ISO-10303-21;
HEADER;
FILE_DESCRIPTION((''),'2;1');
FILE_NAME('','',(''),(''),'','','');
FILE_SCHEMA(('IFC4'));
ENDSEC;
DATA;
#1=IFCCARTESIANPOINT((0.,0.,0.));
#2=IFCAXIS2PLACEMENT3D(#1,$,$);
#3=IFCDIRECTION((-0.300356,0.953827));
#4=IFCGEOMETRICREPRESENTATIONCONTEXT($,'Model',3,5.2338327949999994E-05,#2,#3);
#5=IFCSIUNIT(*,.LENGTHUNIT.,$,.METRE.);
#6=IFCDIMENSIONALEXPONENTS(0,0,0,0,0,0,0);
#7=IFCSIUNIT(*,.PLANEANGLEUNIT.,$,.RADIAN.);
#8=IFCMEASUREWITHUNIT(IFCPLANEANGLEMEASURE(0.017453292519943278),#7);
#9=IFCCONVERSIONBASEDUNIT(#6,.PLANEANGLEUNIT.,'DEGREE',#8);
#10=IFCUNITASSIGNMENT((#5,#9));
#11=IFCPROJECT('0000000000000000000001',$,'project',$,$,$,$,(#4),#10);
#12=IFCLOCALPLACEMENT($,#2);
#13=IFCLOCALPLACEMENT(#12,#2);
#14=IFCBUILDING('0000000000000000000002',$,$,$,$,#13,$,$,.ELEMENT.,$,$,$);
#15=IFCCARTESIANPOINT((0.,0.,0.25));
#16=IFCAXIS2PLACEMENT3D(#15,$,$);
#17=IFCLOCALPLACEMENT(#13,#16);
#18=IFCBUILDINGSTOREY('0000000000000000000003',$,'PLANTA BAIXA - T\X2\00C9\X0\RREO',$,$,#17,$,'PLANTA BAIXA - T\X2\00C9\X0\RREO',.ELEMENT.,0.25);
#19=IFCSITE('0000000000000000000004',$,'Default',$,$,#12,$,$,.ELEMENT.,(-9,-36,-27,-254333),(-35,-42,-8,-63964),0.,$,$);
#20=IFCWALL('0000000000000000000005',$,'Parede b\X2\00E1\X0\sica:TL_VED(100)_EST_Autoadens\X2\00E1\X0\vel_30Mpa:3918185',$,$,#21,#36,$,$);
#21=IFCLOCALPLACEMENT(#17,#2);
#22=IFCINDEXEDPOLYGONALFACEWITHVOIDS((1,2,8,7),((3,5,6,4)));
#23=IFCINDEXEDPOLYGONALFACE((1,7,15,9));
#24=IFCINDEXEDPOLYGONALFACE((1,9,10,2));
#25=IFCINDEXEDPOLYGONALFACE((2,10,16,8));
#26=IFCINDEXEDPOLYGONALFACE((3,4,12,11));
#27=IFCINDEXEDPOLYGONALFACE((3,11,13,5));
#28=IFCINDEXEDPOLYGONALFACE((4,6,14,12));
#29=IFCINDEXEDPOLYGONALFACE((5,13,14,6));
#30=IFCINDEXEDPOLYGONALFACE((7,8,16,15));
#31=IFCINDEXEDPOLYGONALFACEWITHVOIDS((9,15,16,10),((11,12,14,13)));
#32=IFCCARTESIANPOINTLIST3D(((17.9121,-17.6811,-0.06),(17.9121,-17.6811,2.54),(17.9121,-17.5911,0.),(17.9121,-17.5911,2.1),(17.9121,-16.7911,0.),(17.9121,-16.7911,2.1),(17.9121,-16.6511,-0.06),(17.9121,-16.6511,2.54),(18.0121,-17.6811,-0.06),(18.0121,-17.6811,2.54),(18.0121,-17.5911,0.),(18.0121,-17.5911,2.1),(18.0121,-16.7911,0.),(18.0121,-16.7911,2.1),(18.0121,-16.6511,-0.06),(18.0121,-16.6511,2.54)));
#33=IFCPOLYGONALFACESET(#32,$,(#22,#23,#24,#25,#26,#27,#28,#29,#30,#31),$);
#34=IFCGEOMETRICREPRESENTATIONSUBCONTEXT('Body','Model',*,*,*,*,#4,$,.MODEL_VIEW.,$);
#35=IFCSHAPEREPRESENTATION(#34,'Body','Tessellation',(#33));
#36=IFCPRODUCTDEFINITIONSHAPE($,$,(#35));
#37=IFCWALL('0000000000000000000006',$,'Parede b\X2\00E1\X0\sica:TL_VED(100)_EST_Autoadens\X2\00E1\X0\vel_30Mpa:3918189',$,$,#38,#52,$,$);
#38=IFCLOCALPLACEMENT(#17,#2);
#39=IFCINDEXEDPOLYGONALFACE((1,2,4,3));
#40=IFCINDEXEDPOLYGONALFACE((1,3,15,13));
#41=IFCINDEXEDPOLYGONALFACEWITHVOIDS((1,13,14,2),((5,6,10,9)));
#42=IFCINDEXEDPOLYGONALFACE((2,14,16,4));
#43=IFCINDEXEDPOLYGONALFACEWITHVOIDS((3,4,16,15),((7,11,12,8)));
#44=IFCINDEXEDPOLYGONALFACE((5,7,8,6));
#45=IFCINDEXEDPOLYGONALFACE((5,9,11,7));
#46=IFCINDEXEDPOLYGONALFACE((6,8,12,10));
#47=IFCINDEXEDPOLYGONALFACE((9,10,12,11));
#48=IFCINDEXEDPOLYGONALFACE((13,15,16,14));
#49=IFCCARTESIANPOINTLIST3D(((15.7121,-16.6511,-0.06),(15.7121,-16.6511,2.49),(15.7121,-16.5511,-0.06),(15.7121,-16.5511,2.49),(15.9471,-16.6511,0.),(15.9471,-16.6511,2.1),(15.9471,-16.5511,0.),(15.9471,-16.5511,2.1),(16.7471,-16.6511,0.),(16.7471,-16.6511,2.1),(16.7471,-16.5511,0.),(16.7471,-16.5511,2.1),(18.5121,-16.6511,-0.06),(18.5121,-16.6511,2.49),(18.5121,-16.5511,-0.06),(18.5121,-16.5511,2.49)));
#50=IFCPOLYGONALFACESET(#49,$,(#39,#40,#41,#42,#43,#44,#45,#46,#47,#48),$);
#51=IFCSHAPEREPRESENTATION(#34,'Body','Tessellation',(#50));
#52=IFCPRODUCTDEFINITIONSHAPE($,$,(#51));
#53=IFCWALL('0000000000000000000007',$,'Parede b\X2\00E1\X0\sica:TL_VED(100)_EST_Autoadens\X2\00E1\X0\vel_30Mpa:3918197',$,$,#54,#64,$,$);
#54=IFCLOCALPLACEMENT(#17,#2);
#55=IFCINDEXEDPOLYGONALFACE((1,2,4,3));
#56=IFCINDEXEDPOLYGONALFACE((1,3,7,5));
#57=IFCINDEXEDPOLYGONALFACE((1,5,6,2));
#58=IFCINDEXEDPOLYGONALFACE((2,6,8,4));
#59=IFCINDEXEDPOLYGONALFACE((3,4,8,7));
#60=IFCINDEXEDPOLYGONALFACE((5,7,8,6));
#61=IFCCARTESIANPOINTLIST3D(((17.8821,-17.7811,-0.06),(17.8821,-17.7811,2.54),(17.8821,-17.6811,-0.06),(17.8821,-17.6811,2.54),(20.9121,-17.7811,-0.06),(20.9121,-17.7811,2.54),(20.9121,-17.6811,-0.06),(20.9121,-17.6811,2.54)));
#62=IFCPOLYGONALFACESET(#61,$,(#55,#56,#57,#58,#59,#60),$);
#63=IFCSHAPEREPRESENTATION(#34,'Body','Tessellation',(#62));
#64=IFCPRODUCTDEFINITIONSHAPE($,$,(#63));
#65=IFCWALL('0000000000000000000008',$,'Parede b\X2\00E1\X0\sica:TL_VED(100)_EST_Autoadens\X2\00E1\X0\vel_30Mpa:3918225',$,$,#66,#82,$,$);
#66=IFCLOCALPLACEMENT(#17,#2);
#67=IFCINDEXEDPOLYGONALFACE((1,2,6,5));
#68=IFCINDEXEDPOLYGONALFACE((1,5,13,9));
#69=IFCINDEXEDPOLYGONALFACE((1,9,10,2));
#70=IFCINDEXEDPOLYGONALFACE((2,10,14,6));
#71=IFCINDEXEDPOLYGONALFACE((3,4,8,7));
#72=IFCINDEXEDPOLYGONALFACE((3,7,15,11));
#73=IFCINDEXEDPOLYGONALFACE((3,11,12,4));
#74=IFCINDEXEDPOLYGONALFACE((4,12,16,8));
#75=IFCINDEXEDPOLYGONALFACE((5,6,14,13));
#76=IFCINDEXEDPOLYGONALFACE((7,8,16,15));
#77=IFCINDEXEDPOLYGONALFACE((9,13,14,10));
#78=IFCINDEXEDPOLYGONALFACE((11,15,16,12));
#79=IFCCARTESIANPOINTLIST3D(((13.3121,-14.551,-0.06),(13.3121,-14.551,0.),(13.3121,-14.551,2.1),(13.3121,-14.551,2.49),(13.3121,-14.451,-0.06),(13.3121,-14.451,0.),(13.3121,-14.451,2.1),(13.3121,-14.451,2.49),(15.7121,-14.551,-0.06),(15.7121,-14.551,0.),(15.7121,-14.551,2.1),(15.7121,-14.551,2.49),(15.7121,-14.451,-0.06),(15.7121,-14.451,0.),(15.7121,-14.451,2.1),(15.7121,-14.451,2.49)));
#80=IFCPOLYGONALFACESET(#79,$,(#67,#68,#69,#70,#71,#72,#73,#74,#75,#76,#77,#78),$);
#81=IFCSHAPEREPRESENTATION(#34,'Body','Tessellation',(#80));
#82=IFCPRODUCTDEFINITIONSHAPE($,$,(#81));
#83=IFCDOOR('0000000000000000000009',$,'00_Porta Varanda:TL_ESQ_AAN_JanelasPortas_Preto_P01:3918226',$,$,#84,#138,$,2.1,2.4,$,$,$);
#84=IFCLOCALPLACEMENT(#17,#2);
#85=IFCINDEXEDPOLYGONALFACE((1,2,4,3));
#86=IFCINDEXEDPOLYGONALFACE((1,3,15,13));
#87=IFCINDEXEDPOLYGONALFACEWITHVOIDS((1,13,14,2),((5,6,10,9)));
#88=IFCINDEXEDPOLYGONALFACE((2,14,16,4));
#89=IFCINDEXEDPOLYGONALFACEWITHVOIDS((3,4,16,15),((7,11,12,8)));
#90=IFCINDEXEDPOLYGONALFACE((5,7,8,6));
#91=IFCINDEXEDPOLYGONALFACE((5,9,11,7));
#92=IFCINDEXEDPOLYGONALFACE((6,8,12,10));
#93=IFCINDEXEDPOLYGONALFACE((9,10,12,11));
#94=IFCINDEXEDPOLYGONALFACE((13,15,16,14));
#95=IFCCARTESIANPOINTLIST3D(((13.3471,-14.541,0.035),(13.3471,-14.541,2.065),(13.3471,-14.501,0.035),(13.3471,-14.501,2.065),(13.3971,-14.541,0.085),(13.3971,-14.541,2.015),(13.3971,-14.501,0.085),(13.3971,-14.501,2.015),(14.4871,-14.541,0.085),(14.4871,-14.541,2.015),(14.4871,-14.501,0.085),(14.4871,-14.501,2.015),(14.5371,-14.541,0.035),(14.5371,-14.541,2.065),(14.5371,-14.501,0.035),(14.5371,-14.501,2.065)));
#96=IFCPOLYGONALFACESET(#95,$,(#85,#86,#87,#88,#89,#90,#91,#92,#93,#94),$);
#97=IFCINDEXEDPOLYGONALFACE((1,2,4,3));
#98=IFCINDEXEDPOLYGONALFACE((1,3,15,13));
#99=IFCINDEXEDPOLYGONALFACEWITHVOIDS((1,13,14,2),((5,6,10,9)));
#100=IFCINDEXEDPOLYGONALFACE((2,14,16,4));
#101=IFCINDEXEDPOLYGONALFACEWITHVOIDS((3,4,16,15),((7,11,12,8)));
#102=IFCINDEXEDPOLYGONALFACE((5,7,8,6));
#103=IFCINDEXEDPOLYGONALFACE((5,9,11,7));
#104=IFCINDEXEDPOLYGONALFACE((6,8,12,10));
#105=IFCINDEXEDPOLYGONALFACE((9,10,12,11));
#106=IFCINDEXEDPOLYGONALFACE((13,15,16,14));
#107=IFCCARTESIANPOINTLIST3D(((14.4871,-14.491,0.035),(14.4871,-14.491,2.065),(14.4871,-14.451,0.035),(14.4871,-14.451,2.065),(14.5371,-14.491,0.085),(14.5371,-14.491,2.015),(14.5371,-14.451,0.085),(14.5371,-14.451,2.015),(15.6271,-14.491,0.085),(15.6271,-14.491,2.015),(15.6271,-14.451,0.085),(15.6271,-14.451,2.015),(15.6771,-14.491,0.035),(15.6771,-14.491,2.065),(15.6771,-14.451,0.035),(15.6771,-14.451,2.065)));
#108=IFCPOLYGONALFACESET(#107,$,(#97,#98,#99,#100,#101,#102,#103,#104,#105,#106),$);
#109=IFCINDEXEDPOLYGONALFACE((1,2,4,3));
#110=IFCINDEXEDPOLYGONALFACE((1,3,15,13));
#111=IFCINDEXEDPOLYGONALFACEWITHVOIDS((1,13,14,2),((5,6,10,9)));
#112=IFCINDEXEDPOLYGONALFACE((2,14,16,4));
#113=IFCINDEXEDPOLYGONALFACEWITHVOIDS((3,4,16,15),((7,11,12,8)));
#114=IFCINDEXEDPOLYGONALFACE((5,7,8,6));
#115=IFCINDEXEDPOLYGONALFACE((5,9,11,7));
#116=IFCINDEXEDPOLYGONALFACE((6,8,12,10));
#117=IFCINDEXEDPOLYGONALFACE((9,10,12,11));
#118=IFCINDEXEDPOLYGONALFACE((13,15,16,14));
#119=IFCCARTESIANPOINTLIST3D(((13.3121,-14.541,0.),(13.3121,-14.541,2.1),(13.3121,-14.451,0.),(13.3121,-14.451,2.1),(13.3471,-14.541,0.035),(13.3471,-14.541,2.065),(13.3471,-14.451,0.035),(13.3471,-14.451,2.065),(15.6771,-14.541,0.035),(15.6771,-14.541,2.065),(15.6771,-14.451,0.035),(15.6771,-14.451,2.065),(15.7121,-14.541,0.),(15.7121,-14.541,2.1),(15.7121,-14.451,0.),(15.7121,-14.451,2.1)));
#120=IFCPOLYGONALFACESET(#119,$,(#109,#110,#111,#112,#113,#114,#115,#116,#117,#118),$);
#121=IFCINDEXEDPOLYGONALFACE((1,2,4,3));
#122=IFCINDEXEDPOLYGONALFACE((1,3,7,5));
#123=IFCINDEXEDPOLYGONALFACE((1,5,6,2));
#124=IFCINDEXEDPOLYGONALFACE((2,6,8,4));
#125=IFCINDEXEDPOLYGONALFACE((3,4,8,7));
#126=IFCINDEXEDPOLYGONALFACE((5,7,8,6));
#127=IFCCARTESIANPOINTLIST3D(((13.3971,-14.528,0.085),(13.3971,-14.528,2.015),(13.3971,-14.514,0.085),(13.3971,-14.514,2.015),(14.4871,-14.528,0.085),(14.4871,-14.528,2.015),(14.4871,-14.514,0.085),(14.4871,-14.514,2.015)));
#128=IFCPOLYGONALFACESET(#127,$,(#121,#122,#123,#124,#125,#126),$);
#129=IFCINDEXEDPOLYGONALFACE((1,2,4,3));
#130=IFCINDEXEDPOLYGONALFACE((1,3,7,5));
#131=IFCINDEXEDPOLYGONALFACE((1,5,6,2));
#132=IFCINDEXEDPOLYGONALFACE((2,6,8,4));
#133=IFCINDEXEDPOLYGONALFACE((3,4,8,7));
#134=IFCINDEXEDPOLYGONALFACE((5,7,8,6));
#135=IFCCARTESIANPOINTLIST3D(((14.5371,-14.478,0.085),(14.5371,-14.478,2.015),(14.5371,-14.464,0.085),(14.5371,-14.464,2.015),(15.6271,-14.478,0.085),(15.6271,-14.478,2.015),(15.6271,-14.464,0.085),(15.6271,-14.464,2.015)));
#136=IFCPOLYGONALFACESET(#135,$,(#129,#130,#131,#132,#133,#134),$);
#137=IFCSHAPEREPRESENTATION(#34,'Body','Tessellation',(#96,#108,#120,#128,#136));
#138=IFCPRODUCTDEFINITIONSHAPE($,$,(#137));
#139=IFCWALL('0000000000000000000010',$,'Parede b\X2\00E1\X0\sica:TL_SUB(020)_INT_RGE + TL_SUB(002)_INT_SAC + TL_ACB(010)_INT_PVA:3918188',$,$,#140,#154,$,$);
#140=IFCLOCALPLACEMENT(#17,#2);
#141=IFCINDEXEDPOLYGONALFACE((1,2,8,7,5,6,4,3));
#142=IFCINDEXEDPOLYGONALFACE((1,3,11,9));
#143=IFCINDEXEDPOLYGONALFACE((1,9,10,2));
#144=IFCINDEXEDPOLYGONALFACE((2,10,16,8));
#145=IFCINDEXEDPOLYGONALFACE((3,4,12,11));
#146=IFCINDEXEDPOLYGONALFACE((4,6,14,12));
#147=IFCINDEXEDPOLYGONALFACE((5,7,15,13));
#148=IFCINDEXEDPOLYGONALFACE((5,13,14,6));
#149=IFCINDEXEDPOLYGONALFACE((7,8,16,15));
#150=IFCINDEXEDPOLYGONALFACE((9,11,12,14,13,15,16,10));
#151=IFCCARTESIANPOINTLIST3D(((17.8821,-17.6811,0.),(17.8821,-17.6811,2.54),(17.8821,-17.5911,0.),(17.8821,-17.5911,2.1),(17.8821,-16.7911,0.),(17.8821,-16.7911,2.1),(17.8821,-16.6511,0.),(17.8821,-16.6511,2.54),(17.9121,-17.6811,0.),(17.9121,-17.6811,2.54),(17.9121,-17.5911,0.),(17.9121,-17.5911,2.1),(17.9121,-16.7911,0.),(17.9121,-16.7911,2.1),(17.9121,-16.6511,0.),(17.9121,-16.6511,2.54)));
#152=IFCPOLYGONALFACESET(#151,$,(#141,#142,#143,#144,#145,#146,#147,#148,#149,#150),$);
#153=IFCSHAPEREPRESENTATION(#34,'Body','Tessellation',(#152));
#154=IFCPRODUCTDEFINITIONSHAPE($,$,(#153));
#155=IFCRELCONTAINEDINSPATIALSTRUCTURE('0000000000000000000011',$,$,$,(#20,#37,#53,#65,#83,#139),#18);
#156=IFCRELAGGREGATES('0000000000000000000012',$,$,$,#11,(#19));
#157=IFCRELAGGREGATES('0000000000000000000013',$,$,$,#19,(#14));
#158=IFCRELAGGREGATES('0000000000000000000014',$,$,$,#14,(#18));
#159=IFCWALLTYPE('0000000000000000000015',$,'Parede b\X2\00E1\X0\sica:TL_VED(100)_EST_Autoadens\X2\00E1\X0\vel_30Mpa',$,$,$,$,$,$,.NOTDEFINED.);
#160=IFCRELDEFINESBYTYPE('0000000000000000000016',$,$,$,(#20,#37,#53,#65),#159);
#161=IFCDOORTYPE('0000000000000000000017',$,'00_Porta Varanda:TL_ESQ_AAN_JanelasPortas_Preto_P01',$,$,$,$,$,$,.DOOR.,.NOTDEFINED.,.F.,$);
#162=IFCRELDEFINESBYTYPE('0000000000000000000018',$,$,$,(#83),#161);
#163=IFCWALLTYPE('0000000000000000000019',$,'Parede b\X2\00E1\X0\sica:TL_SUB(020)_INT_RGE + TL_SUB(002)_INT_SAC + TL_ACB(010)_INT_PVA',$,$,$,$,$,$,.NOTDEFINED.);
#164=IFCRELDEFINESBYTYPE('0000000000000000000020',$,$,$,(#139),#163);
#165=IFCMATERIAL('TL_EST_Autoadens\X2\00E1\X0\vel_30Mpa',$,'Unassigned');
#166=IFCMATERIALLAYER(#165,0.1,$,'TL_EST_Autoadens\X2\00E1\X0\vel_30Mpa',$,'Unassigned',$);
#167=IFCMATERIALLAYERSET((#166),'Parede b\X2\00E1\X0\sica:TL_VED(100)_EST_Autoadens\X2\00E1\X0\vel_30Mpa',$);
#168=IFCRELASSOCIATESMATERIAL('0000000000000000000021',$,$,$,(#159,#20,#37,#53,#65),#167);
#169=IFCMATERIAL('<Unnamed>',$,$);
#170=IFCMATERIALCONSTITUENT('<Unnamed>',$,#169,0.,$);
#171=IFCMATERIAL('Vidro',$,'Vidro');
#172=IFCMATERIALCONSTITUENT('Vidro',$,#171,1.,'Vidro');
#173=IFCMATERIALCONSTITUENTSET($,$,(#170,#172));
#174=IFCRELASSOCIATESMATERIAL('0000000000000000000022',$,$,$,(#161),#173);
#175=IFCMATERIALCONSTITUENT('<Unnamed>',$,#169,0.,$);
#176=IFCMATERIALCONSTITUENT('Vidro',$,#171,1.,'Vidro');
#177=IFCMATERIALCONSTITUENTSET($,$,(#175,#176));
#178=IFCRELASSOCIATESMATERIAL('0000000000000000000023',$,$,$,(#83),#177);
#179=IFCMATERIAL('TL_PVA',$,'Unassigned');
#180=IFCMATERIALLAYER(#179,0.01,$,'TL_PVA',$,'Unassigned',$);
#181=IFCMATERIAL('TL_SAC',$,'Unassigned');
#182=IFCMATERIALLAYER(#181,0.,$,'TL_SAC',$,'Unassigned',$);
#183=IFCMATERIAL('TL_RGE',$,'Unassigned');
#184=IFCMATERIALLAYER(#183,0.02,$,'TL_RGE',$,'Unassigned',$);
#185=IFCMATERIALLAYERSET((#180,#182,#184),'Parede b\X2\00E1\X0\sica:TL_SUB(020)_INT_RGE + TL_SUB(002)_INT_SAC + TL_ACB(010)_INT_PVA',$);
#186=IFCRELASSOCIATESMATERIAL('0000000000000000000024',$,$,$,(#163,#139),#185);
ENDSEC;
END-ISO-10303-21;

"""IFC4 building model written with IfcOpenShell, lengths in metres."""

from ifc_helpers import new_model, entity, si_unit, converted_unit, direction, frame, frame_2d, origin, place, context, subcontext, project, spatial, polyline, rectangle, outline, extrude, source, transform, mapped, material, layer, layer_set, layer_usage, constituent, constituent_set, type_object, type_shapes, element, fill, save


model = new_model("IFC4")

# Units and contexts
model_context = context("Model", 3, precision=5.2338327949999994e-05, world=origin(), true_north=direction((-0.300356, 0.953827)))
body_context = subcontext(model_context, "Body", "Model", "MODEL_VIEW")
ifc_project = project(units=[si_unit("LENGTHUNIT", "METRE"), converted_unit("PLANEANGLEUNIT", "DEGREE", entity("IfcPlaneAngleMeasure", 0.017453292519943278), si_unit("PLANEANGLEUNIT", "RADIAN"), dimensions=[0, 0, 0, 0, 0, 0, 0])], contexts=[model_context])

# Site, building, storey
site_placement = place(None, origin())
site = spatial("IfcSite", under=ifc_project, at=site_placement, Name="Default", CompositionType="ELEMENT", RefLatitude=(-9, -36, -27, -254333), RefLongitude=(-35, -42, -8, -63964), RefElevation=0.0)
building_placement = place(site_placement, origin())
building = spatial("IfcBuilding", under=site, at=building_placement, CompositionType="ELEMENT")
storey_placement = place(building_placement, frame((0.0, 0.0, 0.25)))
storey = spatial("IfcBuildingStorey", under=building, at=storey_placement, Name="PLANTA BAIXA - TÉRREO", LongName="PLANTA BAIXA - TÉRREO", CompositionType="ELEMENT", Elevation=0.25)

# Walls, openings
ifc_material_1 = material(Name="TL_EST_Autoadensável_30Mpa", Category="Unassigned")
ifc_layer_1 = layer(ifc_material_1, 0.1, Name="TL_EST_Autoadensável_30Mpa", Category="Unassigned")
ifc_layer_set_1 = layer_set([ifc_layer_1], Name="Parede básica:TL_VED(100)_EST_Autoadensável_30Mpa")
ifc_layer_usage_1 = layer_usage(ifc_layer_set_1, "AXIS2", "NEGATIVE", 0.05)
wall_type_1 = type_object("IfcWallType", Name="Parede básica:TL_VED(100)_EST_Autoadensável_30Mpa", PredefinedType="NOTDEFINED", material=ifc_layer_set_1)
wall_1_placement = place(storey_placement, frame((17.9621, -16.6511, -0.06), z_axis=(0.0, 0.0, 1.0), x_axis=(0.0, -1.0, 0.0)))
wall_1 = element("IfcWall", 1, at=wall_1_placement, inside=storey, type_object=wall_type_1, material=ifc_layer_usage_1, Name="Parede básica:TL_VED(100)_EST_Autoadensável_30Mpa:3918185", context=body_context, shape_type="SweptSolid", body=[
    extrude(rectangle(XDim=1.03, YDim=0.1, at=frame_2d((0.515, 0.0), x_axis=(-1.0, 0.0))), origin(), (0.0, 0.0, 1.0), 2.6),
])
opening_1_placement = place(wall_1_placement, frame((0.14, -0.05, 0.06)))
element("IfcOpeningElement", 2, at=opening_1_placement, cuts=wall_1, PredefinedType="OPENING", context=body_context, shape_type="SweptSolid", body=[
    extrude(rectangle(XDim=2.1, YDim=0.8, at=frame_2d((1.05, 0.4), x_axis=(1.0, 0.0))), frame((0.0, 0.0, 0.0), z_axis=(0.0, 1.0, 0.0), x_axis=(0.0, 0.0, 1.0)), (0.0, 0.0, 1.0), 0.1),
])
ifc_layer_usage_2 = layer_usage(ifc_layer_set_1, "AXIS2", "NEGATIVE", 0.05)
wall_2_placement = place(storey_placement, frame((15.7121, -16.6011, -0.06)))
wall_2 = element("IfcWall", 3, at=wall_2_placement, inside=storey, type_object=wall_type_1, material=ifc_layer_usage_2, Name="Parede básica:TL_VED(100)_EST_Autoadensável_30Mpa:3918189", context=body_context, shape_type="SweptSolid", body=[
    extrude(rectangle(XDim=2.8, YDim=0.1, at=frame_2d((1.4, 0.0), x_axis=(-1.0, 0.0))), origin(), (0.0, 0.0, 1.0), 2.55),
])
opening_2_placement = place(wall_2_placement, frame((0.235, -0.05, 0.06)))
element("IfcOpeningElement", 4, at=opening_2_placement, cuts=wall_2, PredefinedType="OPENING", context=body_context, shape_type="SweptSolid", body=[
    extrude(rectangle(XDim=2.1, YDim=0.8, at=frame_2d((1.05, 0.4), x_axis=(1.0, 0.0))), frame((0.0, 0.0, 0.0), z_axis=(0.0, 1.0, 0.0), x_axis=(0.0, 0.0, 1.0)), (0.0, 0.0, 1.0), 0.1),
])

# Wall
ifc_layer_usage_3 = layer_usage(ifc_layer_set_1, "AXIS2", "POSITIVE", -0.05)
wall_3_placement = place(storey_placement, frame((17.8821, -17.7311, -0.06)))
element("IfcWall", 5, at=wall_3_placement, inside=storey, type_object=wall_type_1, material=ifc_layer_usage_3, Name="Parede básica:TL_VED(100)_EST_Autoadensável_30Mpa:3918197", context=body_context, shape_type="SweptSolid", body=[
    extrude(rectangle(XDim=3.03, YDim=0.1, at=frame_2d((1.515, 0.0), x_axis=(-1.0, 0.0))), origin(), (0.0, 0.0, 1.0), 2.6),
])

# Wall, opening, door
ifc_layer_usage_4 = layer_usage(ifc_layer_set_1, "AXIS2", "POSITIVE", -0.05)
wall_4_placement = place(storey_placement, frame((15.7121, -14.501, -0.06), z_axis=(0.0, 0.0, 1.0), x_axis=(-1.0, 0.0, 0.0)))
wall_4 = element("IfcWall", 6, at=wall_4_placement, inside=storey, type_object=wall_type_1, material=ifc_layer_usage_4, Name="Parede básica:TL_VED(100)_EST_Autoadensável_30Mpa:3918225", context=body_context, shape_type="SweptSolid", body=[
    extrude(rectangle(XDim=2.4, YDim=0.1, at=frame_2d((1.2, 0.0), x_axis=(-1.0, 0.0))), origin(), (0.0, 0.0, 1.0), 2.55),
])
opening_3_placement = place(wall_4_placement, frame((0.0, -0.05, 0.06)))
opening_3 = element("IfcOpeningElement", 7, at=opening_3_placement, cuts=wall_4, PredefinedType="OPENING", context=body_context, shape_type="SweptSolid", body=[
    extrude(rectangle(XDim=2.1, YDim=2.4, at=frame_2d((1.05, 1.2), x_axis=(1.0, 0.0))), frame((0.0, 0.0, 0.0), z_axis=(0.0, 1.0, 0.0), x_axis=(0.0, 0.0, 1.0)), (0.0, 0.0, 1.0), 0.1),
])
ifc_material_2 = material(Name="<Unnamed>")
ifc_constituent_1 = constituent(ifc_material_2, Name="<Unnamed>", fraction=0.0)
ifc_material_3 = material(Name="Vidro", Category="Vidro")
ifc_constituent_2 = constituent(ifc_material_3, Name="Vidro", Category="Vidro", fraction=1.0)
ifc_constituent_set_1 = constituent_set(constituents=[ifc_constituent_1, ifc_constituent_2])
ifc_constituent_3 = constituent(ifc_material_2, Name="<Unnamed>", fraction=0.0)
ifc_constituent_4 = constituent(ifc_material_3, Name="Vidro", Category="Vidro", fraction=1.0)
ifc_constituent_set_2 = constituent_set(constituents=[ifc_constituent_3, ifc_constituent_4])
door_type = type_object("IfcDoorType", Name="00_Porta Varanda:TL_ESQ_AAN_JanelasPortas_Preto_P01", OperationType="NOTDEFINED", ParameterTakesPrecedence=False, PredefinedType="DOOR", material=ifc_constituent_set_2)
shared_shape = source(origin(), body_context, "Body", "SweptSolid", [
    extrude(outline(polyline([(-1.015, -0.595), (1.015, -0.595), (1.015, 0.595), (-1.015, 0.595), (-1.015, -0.595)]), holes=[polyline([(0.965, -0.545), (-0.965, -0.545), (-0.965, 0.545), (0.965, 0.545), (0.965, -0.545)])]), frame((1.77, 0.05, 1.05), z_axis=(0.0, 1.0, 0.0), x_axis=(0.0, 0.0, 1.0)), (0.0, 0.0, 1.0), 0.04),
    extrude(outline(polyline([(-1.015, -0.595), (1.015, -0.595), (1.015, 0.595), (-1.015, 0.595), (-1.015, -0.595)]), holes=[polyline([(0.965, -0.545), (-0.965, -0.545), (-0.965, 0.545), (0.965, 0.545), (0.965, -0.545)])]), frame((0.63, 0.0, 1.05), z_axis=(0.0, 1.0, 0.0), x_axis=(0.0, 0.0, -1.0)), (0.0, 0.0, 1.0), 0.04),
    extrude(outline(polyline([(-1.05, -1.2), (1.05, -1.2), (1.05, 1.2), (-1.05, 1.2), (-1.05, -1.2)]), holes=[polyline([(1.015, -1.165), (-1.015, -1.165), (-1.015, 1.165), (1.015, 1.165), (1.015, -1.165)])]), frame((1.2, 0.0, 1.05), z_axis=(0.0, 1.0, 0.0), x_axis=(0.0, 0.0, -1.0)), (0.0, 0.0, 1.0), 0.09),
    extrude(rectangle(XDim=0.014, YDim=1.09, at=frame_2d((0.0, 0.0), x_axis=(1.0, 0.0))), frame((1.77, 0.07, 0.085), z_axis=(0.0, 0.0, 1.0), x_axis=(0.0, -1.0, 0.0)), (0.0, 0.0, 1.0), 1.93),
    extrude(rectangle(XDim=0.014, YDim=1.09, at=frame_2d((0.0, 0.0), x_axis=(1.0, 0.0))), frame((0.63, 0.02, 0.085), z_axis=(0.0, 0.0, 1.0), x_axis=(0.0, -1.0, 0.0)), (0.0, 0.0, 1.0), 1.93),
])
type_shapes(door_type, [shared_shape])
door_placement = place(opening_3_placement, origin())
door = element("IfcDoor", 8, at=door_placement, inside=storey, type_object=door_type, material=ifc_constituent_set_1, Name="00_Porta Varanda:TL_ESQ_AAN_JanelasPortas_Preto_P01:3918226", OverallHeight=2.1, OverallWidth=2.4, context=body_context, shape_type="MappedRepresentation", body=[
    mapped(shared_shape, transform((0.0, 0.0, 0.0), scale=1.0)),
])
fill(opening_3, door)

# Wall, opening
ifc_material_4 = material(Name="TL_PVA", Category="Unassigned")
ifc_layer_2 = layer(ifc_material_4, 0.01, Name="TL_PVA", Category="Unassigned")
ifc_material_5 = material(Name="TL_SAC", Category="Unassigned")
ifc_layer_3 = layer(ifc_material_5, 0.0, Name="TL_SAC", Category="Unassigned")
ifc_material_6 = material(Name="TL_RGE", Category="Unassigned")
ifc_layer_4 = layer(ifc_material_6, 0.02, Name="TL_RGE", Category="Unassigned")
ifc_layer_set_2 = layer_set([ifc_layer_2, ifc_layer_3, ifc_layer_4], Name="Parede básica:TL_SUB(020)_INT_RGE + TL_SUB(002)_INT_SAC + TL_ACB(010)_INT_PVA")
ifc_layer_usage_5 = layer_usage(ifc_layer_set_2, "AXIS2", "NEGATIVE", 0.015)
wall_type_2 = type_object("IfcWallType", Name="Parede básica:TL_SUB(020)_INT_RGE + TL_SUB(002)_INT_SAC + TL_ACB(010)_INT_PVA", PredefinedType="NOTDEFINED", material=ifc_layer_set_2)
wall_5_placement = place(storey_placement, frame((17.8971, -17.6811, 0.0), z_axis=(0.0, 0.0, 1.0), x_axis=(0.0, 1.0, 0.0)))
wall_5 = element("IfcWall", 9, at=wall_5_placement, inside=storey, type_object=wall_type_2, material=ifc_layer_usage_5, Name="Parede básica:TL_SUB(020)_INT_RGE + TL_SUB(002)_INT_SAC + TL_ACB(010)_INT_PVA:3918188", context=body_context, shape_type="SweptSolid", body=[
    extrude(rectangle(XDim=1.03, YDim=0.03, at=frame_2d((0.515, 0.0), x_axis=(-1.0, 0.0))), origin(), (0.0, 0.0, 1.0), 2.54),
])
opening_4_placement = place(wall_5_placement, frame((17.6811, 17.8971, 0.0)))
element("IfcOpeningElement", 10, at=opening_4_placement, cuts=wall_5, PredefinedType="OPENING", context=body_context, shape_type="SweptSolid", body=[
    extrude(rectangle(XDim=2.1, YDim=0.8, at=frame_2d((0.0, 0.0), x_axis=(1.0, 0.0))), frame((-17.1911, -19.4361, 1.05), z_axis=(0.0, 1.0, 0.0), x_axis=(0.0, 0.0, 1.0)), (0.0, 0.0, 1.0), 3.048),
])

save(model, "model.ifc")
